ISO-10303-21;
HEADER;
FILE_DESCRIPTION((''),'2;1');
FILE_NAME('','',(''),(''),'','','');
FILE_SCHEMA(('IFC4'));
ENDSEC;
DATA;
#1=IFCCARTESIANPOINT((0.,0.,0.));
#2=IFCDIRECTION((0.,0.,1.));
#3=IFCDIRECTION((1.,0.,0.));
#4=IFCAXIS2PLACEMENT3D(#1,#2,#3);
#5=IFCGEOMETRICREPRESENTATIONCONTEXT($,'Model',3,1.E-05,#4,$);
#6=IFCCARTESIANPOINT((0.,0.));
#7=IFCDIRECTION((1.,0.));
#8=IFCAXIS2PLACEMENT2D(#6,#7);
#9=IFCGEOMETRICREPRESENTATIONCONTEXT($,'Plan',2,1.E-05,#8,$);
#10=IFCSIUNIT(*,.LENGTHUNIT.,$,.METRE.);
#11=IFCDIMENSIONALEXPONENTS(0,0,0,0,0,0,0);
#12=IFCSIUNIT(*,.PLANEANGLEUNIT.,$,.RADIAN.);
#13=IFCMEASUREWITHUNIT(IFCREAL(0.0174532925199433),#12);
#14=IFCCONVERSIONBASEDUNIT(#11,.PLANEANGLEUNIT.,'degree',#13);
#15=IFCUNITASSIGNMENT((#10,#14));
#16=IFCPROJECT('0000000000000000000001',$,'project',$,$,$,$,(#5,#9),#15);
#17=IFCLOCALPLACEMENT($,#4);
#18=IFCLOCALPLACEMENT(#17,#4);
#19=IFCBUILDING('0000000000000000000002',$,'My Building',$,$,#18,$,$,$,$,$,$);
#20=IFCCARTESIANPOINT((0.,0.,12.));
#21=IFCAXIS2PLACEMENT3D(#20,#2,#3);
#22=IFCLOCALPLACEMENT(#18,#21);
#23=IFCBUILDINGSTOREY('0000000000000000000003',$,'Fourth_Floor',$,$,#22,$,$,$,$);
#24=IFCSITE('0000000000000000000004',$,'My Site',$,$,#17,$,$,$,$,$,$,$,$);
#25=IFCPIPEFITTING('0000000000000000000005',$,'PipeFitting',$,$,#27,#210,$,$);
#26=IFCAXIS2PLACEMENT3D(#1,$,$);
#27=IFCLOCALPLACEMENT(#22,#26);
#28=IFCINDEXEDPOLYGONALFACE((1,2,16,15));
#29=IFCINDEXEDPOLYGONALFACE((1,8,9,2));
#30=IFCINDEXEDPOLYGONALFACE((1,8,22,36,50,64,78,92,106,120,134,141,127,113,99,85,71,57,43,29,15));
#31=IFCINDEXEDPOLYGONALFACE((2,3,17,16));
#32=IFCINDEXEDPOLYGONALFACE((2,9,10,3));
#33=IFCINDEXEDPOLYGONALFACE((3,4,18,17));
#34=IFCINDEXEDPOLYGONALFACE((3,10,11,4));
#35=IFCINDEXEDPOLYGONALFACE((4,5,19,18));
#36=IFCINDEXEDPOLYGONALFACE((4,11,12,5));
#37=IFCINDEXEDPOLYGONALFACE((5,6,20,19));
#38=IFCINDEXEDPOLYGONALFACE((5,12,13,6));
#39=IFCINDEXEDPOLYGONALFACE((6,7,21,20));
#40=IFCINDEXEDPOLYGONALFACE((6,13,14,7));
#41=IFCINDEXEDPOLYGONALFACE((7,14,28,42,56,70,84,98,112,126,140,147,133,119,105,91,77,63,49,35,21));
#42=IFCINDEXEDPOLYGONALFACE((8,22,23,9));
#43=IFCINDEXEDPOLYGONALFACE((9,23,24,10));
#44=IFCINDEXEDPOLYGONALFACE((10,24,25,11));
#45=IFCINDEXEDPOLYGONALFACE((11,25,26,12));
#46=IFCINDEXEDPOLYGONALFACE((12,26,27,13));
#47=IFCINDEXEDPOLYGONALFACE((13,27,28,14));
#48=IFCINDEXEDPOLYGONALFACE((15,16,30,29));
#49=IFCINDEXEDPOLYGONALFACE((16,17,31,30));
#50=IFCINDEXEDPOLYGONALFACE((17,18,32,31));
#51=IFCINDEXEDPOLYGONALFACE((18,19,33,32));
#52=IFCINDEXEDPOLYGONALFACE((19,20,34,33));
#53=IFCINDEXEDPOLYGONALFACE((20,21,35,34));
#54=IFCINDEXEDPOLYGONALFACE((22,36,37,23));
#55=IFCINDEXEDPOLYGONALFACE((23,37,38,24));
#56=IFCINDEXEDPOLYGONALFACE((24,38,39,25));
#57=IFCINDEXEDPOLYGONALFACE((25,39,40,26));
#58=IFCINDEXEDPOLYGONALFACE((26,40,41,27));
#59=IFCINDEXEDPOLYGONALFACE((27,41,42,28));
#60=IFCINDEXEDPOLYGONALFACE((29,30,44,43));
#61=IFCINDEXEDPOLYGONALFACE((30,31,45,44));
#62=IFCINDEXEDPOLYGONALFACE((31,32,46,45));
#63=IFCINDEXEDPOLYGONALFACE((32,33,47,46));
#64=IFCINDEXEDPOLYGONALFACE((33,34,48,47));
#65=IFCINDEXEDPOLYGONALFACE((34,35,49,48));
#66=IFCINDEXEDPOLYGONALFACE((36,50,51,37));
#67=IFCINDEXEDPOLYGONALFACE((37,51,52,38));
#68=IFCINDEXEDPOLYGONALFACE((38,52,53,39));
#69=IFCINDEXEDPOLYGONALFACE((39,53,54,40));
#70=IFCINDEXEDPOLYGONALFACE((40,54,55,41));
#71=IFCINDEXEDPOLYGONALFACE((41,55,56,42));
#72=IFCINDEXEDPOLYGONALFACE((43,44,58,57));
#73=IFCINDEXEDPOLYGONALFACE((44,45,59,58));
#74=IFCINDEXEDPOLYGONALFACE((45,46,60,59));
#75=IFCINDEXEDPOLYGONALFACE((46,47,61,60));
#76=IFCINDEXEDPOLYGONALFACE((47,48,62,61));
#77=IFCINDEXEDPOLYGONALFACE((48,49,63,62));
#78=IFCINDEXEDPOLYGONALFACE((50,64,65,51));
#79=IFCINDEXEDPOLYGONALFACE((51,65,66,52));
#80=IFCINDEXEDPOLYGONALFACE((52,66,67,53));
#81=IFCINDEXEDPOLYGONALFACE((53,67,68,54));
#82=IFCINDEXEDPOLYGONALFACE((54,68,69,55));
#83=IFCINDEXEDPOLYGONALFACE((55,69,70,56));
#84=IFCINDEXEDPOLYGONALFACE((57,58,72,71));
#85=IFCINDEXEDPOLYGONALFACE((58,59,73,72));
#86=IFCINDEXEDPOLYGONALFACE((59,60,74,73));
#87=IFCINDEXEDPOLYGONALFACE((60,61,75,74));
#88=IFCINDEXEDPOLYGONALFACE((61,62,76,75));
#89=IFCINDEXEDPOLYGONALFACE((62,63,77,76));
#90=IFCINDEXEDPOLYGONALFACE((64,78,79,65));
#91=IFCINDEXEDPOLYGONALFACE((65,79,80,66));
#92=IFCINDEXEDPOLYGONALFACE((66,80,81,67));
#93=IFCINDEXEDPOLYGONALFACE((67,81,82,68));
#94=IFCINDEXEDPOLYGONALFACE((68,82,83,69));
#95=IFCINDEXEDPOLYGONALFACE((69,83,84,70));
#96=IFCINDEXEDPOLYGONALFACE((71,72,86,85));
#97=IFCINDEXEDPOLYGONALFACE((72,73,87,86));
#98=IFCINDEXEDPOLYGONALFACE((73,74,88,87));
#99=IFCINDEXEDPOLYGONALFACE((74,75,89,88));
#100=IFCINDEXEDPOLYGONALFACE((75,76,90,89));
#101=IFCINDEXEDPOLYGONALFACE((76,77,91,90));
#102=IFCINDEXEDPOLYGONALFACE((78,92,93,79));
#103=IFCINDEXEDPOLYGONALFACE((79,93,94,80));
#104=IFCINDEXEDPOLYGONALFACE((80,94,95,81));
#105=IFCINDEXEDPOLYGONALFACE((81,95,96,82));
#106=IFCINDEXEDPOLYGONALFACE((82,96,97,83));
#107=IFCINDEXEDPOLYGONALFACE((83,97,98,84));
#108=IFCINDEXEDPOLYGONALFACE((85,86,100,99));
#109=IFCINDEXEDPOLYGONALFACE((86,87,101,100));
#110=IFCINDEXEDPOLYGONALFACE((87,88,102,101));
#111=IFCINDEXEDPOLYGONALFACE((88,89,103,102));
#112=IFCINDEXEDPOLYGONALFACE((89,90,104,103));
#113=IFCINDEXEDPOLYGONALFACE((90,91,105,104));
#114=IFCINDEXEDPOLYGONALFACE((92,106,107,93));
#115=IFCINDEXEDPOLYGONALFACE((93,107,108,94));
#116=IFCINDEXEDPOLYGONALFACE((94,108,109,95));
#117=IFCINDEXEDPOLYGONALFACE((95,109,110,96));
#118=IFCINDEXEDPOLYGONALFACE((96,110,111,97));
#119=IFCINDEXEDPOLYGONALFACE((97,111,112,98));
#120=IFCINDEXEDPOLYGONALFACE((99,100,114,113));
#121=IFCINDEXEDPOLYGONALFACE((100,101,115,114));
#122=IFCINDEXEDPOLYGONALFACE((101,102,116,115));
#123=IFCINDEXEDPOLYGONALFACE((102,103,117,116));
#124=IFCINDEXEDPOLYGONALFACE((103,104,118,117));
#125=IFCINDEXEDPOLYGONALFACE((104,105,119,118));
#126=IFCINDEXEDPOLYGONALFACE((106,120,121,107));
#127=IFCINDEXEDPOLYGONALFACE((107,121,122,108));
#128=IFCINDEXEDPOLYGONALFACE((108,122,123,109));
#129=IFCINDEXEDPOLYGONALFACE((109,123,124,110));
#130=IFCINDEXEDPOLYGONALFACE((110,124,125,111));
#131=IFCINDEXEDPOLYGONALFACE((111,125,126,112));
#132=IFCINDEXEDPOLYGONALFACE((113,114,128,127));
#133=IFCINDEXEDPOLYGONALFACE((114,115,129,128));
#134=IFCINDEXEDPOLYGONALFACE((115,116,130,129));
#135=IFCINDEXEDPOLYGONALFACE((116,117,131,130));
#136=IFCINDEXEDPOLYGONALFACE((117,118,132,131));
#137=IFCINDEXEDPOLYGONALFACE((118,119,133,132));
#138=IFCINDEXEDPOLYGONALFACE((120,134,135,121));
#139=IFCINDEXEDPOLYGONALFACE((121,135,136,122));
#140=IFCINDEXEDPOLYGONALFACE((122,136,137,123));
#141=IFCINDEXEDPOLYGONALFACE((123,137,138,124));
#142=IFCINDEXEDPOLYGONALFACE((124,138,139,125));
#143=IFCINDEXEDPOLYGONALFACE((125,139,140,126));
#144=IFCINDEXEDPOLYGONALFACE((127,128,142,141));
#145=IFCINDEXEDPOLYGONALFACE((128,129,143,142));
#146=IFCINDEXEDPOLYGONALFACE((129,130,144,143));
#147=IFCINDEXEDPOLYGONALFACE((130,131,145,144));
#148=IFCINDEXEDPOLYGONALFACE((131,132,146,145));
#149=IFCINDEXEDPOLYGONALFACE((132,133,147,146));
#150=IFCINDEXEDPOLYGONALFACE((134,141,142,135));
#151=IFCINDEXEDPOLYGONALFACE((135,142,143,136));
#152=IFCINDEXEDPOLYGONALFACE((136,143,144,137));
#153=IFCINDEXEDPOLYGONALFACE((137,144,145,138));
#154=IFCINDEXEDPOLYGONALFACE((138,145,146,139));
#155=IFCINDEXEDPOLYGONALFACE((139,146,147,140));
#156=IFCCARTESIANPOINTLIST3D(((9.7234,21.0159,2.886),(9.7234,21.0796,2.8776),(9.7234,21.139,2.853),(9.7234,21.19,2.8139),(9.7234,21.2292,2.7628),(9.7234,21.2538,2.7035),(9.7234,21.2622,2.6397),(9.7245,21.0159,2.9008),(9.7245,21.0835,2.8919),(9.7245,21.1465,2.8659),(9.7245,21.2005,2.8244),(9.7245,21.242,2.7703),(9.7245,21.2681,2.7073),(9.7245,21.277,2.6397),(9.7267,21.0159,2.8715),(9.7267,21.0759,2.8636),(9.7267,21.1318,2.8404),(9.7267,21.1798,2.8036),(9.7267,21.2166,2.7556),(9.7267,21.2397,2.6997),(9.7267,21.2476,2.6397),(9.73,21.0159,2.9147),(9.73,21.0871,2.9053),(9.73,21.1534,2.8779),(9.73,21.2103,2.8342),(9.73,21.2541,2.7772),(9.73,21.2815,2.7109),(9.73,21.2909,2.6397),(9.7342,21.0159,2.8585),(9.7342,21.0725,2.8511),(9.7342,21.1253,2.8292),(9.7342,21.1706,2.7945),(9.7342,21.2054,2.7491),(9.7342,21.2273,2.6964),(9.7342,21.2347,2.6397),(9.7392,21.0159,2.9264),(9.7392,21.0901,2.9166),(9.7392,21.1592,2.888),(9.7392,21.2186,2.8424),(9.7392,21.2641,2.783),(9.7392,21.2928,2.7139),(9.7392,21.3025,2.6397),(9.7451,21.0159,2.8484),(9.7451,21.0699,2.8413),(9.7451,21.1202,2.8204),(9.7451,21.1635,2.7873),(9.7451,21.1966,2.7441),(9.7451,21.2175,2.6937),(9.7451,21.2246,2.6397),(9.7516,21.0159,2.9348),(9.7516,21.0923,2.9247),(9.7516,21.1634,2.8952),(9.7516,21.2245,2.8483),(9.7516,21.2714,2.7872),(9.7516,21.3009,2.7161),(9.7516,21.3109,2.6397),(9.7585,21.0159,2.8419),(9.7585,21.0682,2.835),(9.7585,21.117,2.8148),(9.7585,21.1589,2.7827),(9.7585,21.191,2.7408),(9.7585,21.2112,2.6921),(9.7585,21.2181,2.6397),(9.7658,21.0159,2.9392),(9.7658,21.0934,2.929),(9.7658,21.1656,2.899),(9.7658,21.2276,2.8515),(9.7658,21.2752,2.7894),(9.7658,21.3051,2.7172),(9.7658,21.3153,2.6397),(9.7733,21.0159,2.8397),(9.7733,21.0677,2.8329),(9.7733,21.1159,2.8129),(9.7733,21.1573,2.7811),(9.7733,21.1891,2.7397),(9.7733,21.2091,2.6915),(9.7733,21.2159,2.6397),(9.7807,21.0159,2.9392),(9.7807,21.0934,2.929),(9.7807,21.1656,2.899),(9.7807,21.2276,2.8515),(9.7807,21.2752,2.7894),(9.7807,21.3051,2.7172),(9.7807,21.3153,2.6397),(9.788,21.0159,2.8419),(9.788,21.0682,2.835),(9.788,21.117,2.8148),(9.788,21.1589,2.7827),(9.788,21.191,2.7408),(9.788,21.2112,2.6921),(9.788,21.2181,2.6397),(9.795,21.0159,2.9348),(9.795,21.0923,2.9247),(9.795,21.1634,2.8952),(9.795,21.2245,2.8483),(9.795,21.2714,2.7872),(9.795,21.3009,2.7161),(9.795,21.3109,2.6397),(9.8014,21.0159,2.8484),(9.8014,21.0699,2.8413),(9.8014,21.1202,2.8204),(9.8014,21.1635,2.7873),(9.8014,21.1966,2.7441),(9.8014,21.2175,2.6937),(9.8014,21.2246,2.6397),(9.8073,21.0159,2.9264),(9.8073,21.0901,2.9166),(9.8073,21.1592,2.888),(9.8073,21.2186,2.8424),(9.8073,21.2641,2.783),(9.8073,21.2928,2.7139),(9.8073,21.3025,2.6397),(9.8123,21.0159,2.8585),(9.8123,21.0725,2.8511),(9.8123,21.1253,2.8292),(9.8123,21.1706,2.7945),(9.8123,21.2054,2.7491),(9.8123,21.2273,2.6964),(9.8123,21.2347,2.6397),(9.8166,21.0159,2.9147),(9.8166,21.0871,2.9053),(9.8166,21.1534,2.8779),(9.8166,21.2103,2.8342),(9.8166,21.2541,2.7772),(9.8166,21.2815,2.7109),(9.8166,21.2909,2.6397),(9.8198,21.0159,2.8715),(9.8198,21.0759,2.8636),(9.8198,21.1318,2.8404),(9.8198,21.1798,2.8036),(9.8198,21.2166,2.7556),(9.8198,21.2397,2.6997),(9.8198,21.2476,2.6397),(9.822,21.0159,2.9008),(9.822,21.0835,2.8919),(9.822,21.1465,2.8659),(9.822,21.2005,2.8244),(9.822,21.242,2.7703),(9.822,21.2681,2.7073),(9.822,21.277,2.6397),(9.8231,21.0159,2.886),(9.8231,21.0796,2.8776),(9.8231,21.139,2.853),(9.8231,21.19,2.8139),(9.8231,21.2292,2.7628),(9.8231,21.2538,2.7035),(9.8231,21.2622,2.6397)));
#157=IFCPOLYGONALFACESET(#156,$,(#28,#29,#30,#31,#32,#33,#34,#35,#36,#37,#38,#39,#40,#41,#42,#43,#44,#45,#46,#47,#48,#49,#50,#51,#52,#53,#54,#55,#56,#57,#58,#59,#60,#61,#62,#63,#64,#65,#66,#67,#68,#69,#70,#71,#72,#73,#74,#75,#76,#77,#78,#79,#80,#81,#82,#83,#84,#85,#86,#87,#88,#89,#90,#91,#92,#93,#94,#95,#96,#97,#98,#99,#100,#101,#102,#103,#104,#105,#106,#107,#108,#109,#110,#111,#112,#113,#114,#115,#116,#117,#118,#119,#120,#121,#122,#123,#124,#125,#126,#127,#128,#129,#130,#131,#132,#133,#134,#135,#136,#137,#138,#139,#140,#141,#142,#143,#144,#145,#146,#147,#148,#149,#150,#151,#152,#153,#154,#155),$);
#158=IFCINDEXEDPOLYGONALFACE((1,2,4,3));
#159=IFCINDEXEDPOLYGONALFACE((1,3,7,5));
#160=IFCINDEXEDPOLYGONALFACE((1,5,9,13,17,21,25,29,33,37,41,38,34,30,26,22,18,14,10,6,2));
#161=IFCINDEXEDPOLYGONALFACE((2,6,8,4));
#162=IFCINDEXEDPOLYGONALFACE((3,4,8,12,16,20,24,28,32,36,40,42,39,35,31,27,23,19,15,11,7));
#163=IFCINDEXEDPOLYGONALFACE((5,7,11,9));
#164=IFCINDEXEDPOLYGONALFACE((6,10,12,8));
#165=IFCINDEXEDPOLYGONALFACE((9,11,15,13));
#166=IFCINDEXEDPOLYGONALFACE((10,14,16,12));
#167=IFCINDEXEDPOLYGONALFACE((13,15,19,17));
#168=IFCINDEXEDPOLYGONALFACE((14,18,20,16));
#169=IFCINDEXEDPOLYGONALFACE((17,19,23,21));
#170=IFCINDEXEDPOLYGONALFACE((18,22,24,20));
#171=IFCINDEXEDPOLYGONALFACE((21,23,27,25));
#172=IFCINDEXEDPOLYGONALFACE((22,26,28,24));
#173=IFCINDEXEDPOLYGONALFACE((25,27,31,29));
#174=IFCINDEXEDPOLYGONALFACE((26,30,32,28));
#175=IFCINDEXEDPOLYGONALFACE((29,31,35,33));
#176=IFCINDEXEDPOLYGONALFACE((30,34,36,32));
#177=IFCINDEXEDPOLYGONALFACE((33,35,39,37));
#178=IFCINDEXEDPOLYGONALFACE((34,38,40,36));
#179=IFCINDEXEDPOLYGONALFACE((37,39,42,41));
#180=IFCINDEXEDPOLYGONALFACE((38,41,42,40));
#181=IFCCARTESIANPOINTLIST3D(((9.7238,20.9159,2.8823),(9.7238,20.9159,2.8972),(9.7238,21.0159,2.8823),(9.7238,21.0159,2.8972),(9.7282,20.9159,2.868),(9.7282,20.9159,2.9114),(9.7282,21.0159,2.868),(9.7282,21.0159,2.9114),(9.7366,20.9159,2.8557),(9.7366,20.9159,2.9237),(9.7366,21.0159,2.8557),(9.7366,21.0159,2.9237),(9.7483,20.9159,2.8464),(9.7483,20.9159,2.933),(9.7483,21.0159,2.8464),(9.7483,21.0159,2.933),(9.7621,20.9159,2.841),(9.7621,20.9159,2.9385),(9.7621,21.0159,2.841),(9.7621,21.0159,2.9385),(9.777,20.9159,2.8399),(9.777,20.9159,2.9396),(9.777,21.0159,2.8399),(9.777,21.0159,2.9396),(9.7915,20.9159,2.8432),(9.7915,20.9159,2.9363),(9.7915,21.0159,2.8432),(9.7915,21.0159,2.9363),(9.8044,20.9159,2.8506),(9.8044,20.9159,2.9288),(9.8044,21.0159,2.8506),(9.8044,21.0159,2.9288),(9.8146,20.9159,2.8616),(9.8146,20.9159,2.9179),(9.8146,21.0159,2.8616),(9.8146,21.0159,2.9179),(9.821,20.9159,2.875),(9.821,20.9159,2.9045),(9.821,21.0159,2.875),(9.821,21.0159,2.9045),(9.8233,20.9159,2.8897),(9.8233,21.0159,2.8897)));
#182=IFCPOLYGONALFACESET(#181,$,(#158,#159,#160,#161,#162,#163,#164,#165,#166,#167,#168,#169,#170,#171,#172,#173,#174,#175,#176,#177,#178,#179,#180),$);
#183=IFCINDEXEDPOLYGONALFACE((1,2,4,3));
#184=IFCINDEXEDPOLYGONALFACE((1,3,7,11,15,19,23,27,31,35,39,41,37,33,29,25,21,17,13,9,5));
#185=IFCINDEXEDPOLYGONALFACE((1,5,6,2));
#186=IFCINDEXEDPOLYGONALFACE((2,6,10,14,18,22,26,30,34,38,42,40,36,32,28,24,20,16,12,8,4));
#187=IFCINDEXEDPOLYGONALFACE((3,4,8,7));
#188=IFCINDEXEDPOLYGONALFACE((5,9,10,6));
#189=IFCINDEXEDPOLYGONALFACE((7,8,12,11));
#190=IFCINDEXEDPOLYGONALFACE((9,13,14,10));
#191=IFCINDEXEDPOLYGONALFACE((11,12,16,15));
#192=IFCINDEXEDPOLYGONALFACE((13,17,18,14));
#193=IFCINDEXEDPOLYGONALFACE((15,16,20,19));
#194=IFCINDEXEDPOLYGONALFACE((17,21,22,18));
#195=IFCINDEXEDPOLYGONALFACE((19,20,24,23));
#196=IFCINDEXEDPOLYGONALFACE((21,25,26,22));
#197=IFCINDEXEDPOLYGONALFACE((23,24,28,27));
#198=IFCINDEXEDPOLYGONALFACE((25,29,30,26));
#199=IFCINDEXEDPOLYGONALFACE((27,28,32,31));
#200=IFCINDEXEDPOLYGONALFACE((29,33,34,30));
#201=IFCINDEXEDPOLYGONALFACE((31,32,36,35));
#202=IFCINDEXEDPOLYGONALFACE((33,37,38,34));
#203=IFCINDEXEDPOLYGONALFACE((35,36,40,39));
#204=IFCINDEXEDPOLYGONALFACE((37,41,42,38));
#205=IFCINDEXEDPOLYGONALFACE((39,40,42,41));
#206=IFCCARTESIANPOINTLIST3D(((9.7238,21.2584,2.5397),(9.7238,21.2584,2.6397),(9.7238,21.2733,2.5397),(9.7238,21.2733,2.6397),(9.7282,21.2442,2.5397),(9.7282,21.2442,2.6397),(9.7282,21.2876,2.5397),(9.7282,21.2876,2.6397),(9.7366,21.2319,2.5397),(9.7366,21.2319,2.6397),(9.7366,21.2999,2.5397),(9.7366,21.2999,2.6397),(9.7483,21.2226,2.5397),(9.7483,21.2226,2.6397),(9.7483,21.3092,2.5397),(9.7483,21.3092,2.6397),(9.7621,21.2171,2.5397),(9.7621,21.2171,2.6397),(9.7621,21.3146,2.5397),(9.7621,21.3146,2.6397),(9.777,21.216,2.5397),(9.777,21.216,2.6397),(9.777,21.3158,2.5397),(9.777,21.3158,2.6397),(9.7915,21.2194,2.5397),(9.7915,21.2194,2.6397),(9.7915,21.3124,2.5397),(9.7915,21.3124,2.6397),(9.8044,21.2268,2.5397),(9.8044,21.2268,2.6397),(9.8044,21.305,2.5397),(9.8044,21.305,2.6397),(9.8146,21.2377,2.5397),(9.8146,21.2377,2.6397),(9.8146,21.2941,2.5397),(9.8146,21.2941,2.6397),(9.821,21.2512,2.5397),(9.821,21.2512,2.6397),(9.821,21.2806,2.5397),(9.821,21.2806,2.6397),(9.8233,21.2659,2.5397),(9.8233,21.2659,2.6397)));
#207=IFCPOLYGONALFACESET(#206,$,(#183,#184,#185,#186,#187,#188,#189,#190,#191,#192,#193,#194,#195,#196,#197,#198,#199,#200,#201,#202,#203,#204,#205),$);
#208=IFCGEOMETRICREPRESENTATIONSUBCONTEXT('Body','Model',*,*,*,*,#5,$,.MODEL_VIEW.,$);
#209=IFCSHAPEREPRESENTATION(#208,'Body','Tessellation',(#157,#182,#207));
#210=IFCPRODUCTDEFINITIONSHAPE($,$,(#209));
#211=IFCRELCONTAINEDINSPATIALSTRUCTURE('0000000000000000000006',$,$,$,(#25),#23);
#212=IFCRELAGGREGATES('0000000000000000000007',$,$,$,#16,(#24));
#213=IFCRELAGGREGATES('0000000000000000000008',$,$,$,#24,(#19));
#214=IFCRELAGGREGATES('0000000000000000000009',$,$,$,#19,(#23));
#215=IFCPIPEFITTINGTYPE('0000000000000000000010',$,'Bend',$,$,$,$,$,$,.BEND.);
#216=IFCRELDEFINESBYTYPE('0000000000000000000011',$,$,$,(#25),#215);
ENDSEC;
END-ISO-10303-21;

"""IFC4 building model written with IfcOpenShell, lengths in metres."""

from ifc_helpers import new_model, entity, si_unit, converted_unit, frame, origin_with_axes, origin_2d_with_axis, place, context, subcontext, project, spatial, circle, extrude, source, transform, mapped, type_object, type_shapes, element, save


model = new_model("IFC4")

# Units and contexts
model_context = context("Model", 3, precision=1e-05, world=origin_with_axes())
plan_context = context("Plan", 2, precision=1e-05, world=origin_2d_with_axis())
body_context_1 = subcontext(model_context, "Body", "Model", "MODEL_VIEW")
ifc_project = project(units=[si_unit("LENGTHUNIT", "METRE"), converted_unit("PLANEANGLEUNIT", "degree", entity("IfcReal", 0.0174532925199433), si_unit("PLANEANGLEUNIT", "RADIAN"), dimensions=[0, 0, 0, 0, 0, 0, 0])], contexts=[model_context, plan_context])

# Site, building, storey
site_placement = place(None, origin_with_axes())
site = spatial("IfcSite", under=ifc_project, at=site_placement, Name="My Site")
building_placement = place(site_placement, origin_with_axes())
building = spatial("IfcBuilding", under=site, at=building_placement, Name="My Building")
storey_placement = place(building_placement, frame((0.0, 0.0, 12.0), z_axis=(0.0, 0.0, 1.0), x_axis=(1.0, 0.0, 0.0)))
storey = spatial("IfcBuildingStorey", under=building, at=storey_placement, Name="Fourth_Floor")

# Pipe fitting
pipe_fitting_type = type_object("IfcPipeFittingType", Name="Bend", PredefinedType="BEND")
shared_shape_1 = source(origin_with_axes(), body_context_1, "Body", "SolidModel", [
    entity("IfcSweptDiskSolid", entity("IfcIndexedPolyCurve", entity("IfcCartesianPointList3D", [[0.0, 0.0, -0.1], [0.0, -0.0732, -0.2768], [0.0, -0.25, -0.35]]), [entity("IfcArcIndex", [1, 2, 3])]), 0.05),
    extrude(circle(Radius=0.05), origin_with_axes(), (0.0, 0.0, -1.0), 0.1),
    extrude(circle(Radius=0.05), frame((0.0, -0.25, -0.35), z_axis=(0.0, -1.0, 0.0), x_axis=(1.0, 0.0, 0.0)), (0.0, 0.0, 1.0), 0.1),
])
type_shapes(pipe_fitting_type, [shared_shape_1])
for number, where, z_axis, x_axis, name in (
    (1, (9.7733, 20.9159, 2.8897), (0.0, -1.0, 0.0), (1.0, 0.0, 0.0), "PipeFitting"),
):
    element("IfcPipeFitting", number, at=place(storey_placement, frame(where, z_axis=z_axis, x_axis=x_axis)), inside=storey, type_object=pipe_fitting_type, Name=name, context=body_context_1, shape_type="MappedRepresentation", body=[
        mapped(shared_shape_1, transform((0.0, 0.0, 0.0), x_axis=(1.0, 0.0, 0.0), y_axis=(0.0, 1.0, 0.0), z_axis=(0.0, 0.0, 1.0), scale=1.0)),
    ])

save(model, "model.ifc")
